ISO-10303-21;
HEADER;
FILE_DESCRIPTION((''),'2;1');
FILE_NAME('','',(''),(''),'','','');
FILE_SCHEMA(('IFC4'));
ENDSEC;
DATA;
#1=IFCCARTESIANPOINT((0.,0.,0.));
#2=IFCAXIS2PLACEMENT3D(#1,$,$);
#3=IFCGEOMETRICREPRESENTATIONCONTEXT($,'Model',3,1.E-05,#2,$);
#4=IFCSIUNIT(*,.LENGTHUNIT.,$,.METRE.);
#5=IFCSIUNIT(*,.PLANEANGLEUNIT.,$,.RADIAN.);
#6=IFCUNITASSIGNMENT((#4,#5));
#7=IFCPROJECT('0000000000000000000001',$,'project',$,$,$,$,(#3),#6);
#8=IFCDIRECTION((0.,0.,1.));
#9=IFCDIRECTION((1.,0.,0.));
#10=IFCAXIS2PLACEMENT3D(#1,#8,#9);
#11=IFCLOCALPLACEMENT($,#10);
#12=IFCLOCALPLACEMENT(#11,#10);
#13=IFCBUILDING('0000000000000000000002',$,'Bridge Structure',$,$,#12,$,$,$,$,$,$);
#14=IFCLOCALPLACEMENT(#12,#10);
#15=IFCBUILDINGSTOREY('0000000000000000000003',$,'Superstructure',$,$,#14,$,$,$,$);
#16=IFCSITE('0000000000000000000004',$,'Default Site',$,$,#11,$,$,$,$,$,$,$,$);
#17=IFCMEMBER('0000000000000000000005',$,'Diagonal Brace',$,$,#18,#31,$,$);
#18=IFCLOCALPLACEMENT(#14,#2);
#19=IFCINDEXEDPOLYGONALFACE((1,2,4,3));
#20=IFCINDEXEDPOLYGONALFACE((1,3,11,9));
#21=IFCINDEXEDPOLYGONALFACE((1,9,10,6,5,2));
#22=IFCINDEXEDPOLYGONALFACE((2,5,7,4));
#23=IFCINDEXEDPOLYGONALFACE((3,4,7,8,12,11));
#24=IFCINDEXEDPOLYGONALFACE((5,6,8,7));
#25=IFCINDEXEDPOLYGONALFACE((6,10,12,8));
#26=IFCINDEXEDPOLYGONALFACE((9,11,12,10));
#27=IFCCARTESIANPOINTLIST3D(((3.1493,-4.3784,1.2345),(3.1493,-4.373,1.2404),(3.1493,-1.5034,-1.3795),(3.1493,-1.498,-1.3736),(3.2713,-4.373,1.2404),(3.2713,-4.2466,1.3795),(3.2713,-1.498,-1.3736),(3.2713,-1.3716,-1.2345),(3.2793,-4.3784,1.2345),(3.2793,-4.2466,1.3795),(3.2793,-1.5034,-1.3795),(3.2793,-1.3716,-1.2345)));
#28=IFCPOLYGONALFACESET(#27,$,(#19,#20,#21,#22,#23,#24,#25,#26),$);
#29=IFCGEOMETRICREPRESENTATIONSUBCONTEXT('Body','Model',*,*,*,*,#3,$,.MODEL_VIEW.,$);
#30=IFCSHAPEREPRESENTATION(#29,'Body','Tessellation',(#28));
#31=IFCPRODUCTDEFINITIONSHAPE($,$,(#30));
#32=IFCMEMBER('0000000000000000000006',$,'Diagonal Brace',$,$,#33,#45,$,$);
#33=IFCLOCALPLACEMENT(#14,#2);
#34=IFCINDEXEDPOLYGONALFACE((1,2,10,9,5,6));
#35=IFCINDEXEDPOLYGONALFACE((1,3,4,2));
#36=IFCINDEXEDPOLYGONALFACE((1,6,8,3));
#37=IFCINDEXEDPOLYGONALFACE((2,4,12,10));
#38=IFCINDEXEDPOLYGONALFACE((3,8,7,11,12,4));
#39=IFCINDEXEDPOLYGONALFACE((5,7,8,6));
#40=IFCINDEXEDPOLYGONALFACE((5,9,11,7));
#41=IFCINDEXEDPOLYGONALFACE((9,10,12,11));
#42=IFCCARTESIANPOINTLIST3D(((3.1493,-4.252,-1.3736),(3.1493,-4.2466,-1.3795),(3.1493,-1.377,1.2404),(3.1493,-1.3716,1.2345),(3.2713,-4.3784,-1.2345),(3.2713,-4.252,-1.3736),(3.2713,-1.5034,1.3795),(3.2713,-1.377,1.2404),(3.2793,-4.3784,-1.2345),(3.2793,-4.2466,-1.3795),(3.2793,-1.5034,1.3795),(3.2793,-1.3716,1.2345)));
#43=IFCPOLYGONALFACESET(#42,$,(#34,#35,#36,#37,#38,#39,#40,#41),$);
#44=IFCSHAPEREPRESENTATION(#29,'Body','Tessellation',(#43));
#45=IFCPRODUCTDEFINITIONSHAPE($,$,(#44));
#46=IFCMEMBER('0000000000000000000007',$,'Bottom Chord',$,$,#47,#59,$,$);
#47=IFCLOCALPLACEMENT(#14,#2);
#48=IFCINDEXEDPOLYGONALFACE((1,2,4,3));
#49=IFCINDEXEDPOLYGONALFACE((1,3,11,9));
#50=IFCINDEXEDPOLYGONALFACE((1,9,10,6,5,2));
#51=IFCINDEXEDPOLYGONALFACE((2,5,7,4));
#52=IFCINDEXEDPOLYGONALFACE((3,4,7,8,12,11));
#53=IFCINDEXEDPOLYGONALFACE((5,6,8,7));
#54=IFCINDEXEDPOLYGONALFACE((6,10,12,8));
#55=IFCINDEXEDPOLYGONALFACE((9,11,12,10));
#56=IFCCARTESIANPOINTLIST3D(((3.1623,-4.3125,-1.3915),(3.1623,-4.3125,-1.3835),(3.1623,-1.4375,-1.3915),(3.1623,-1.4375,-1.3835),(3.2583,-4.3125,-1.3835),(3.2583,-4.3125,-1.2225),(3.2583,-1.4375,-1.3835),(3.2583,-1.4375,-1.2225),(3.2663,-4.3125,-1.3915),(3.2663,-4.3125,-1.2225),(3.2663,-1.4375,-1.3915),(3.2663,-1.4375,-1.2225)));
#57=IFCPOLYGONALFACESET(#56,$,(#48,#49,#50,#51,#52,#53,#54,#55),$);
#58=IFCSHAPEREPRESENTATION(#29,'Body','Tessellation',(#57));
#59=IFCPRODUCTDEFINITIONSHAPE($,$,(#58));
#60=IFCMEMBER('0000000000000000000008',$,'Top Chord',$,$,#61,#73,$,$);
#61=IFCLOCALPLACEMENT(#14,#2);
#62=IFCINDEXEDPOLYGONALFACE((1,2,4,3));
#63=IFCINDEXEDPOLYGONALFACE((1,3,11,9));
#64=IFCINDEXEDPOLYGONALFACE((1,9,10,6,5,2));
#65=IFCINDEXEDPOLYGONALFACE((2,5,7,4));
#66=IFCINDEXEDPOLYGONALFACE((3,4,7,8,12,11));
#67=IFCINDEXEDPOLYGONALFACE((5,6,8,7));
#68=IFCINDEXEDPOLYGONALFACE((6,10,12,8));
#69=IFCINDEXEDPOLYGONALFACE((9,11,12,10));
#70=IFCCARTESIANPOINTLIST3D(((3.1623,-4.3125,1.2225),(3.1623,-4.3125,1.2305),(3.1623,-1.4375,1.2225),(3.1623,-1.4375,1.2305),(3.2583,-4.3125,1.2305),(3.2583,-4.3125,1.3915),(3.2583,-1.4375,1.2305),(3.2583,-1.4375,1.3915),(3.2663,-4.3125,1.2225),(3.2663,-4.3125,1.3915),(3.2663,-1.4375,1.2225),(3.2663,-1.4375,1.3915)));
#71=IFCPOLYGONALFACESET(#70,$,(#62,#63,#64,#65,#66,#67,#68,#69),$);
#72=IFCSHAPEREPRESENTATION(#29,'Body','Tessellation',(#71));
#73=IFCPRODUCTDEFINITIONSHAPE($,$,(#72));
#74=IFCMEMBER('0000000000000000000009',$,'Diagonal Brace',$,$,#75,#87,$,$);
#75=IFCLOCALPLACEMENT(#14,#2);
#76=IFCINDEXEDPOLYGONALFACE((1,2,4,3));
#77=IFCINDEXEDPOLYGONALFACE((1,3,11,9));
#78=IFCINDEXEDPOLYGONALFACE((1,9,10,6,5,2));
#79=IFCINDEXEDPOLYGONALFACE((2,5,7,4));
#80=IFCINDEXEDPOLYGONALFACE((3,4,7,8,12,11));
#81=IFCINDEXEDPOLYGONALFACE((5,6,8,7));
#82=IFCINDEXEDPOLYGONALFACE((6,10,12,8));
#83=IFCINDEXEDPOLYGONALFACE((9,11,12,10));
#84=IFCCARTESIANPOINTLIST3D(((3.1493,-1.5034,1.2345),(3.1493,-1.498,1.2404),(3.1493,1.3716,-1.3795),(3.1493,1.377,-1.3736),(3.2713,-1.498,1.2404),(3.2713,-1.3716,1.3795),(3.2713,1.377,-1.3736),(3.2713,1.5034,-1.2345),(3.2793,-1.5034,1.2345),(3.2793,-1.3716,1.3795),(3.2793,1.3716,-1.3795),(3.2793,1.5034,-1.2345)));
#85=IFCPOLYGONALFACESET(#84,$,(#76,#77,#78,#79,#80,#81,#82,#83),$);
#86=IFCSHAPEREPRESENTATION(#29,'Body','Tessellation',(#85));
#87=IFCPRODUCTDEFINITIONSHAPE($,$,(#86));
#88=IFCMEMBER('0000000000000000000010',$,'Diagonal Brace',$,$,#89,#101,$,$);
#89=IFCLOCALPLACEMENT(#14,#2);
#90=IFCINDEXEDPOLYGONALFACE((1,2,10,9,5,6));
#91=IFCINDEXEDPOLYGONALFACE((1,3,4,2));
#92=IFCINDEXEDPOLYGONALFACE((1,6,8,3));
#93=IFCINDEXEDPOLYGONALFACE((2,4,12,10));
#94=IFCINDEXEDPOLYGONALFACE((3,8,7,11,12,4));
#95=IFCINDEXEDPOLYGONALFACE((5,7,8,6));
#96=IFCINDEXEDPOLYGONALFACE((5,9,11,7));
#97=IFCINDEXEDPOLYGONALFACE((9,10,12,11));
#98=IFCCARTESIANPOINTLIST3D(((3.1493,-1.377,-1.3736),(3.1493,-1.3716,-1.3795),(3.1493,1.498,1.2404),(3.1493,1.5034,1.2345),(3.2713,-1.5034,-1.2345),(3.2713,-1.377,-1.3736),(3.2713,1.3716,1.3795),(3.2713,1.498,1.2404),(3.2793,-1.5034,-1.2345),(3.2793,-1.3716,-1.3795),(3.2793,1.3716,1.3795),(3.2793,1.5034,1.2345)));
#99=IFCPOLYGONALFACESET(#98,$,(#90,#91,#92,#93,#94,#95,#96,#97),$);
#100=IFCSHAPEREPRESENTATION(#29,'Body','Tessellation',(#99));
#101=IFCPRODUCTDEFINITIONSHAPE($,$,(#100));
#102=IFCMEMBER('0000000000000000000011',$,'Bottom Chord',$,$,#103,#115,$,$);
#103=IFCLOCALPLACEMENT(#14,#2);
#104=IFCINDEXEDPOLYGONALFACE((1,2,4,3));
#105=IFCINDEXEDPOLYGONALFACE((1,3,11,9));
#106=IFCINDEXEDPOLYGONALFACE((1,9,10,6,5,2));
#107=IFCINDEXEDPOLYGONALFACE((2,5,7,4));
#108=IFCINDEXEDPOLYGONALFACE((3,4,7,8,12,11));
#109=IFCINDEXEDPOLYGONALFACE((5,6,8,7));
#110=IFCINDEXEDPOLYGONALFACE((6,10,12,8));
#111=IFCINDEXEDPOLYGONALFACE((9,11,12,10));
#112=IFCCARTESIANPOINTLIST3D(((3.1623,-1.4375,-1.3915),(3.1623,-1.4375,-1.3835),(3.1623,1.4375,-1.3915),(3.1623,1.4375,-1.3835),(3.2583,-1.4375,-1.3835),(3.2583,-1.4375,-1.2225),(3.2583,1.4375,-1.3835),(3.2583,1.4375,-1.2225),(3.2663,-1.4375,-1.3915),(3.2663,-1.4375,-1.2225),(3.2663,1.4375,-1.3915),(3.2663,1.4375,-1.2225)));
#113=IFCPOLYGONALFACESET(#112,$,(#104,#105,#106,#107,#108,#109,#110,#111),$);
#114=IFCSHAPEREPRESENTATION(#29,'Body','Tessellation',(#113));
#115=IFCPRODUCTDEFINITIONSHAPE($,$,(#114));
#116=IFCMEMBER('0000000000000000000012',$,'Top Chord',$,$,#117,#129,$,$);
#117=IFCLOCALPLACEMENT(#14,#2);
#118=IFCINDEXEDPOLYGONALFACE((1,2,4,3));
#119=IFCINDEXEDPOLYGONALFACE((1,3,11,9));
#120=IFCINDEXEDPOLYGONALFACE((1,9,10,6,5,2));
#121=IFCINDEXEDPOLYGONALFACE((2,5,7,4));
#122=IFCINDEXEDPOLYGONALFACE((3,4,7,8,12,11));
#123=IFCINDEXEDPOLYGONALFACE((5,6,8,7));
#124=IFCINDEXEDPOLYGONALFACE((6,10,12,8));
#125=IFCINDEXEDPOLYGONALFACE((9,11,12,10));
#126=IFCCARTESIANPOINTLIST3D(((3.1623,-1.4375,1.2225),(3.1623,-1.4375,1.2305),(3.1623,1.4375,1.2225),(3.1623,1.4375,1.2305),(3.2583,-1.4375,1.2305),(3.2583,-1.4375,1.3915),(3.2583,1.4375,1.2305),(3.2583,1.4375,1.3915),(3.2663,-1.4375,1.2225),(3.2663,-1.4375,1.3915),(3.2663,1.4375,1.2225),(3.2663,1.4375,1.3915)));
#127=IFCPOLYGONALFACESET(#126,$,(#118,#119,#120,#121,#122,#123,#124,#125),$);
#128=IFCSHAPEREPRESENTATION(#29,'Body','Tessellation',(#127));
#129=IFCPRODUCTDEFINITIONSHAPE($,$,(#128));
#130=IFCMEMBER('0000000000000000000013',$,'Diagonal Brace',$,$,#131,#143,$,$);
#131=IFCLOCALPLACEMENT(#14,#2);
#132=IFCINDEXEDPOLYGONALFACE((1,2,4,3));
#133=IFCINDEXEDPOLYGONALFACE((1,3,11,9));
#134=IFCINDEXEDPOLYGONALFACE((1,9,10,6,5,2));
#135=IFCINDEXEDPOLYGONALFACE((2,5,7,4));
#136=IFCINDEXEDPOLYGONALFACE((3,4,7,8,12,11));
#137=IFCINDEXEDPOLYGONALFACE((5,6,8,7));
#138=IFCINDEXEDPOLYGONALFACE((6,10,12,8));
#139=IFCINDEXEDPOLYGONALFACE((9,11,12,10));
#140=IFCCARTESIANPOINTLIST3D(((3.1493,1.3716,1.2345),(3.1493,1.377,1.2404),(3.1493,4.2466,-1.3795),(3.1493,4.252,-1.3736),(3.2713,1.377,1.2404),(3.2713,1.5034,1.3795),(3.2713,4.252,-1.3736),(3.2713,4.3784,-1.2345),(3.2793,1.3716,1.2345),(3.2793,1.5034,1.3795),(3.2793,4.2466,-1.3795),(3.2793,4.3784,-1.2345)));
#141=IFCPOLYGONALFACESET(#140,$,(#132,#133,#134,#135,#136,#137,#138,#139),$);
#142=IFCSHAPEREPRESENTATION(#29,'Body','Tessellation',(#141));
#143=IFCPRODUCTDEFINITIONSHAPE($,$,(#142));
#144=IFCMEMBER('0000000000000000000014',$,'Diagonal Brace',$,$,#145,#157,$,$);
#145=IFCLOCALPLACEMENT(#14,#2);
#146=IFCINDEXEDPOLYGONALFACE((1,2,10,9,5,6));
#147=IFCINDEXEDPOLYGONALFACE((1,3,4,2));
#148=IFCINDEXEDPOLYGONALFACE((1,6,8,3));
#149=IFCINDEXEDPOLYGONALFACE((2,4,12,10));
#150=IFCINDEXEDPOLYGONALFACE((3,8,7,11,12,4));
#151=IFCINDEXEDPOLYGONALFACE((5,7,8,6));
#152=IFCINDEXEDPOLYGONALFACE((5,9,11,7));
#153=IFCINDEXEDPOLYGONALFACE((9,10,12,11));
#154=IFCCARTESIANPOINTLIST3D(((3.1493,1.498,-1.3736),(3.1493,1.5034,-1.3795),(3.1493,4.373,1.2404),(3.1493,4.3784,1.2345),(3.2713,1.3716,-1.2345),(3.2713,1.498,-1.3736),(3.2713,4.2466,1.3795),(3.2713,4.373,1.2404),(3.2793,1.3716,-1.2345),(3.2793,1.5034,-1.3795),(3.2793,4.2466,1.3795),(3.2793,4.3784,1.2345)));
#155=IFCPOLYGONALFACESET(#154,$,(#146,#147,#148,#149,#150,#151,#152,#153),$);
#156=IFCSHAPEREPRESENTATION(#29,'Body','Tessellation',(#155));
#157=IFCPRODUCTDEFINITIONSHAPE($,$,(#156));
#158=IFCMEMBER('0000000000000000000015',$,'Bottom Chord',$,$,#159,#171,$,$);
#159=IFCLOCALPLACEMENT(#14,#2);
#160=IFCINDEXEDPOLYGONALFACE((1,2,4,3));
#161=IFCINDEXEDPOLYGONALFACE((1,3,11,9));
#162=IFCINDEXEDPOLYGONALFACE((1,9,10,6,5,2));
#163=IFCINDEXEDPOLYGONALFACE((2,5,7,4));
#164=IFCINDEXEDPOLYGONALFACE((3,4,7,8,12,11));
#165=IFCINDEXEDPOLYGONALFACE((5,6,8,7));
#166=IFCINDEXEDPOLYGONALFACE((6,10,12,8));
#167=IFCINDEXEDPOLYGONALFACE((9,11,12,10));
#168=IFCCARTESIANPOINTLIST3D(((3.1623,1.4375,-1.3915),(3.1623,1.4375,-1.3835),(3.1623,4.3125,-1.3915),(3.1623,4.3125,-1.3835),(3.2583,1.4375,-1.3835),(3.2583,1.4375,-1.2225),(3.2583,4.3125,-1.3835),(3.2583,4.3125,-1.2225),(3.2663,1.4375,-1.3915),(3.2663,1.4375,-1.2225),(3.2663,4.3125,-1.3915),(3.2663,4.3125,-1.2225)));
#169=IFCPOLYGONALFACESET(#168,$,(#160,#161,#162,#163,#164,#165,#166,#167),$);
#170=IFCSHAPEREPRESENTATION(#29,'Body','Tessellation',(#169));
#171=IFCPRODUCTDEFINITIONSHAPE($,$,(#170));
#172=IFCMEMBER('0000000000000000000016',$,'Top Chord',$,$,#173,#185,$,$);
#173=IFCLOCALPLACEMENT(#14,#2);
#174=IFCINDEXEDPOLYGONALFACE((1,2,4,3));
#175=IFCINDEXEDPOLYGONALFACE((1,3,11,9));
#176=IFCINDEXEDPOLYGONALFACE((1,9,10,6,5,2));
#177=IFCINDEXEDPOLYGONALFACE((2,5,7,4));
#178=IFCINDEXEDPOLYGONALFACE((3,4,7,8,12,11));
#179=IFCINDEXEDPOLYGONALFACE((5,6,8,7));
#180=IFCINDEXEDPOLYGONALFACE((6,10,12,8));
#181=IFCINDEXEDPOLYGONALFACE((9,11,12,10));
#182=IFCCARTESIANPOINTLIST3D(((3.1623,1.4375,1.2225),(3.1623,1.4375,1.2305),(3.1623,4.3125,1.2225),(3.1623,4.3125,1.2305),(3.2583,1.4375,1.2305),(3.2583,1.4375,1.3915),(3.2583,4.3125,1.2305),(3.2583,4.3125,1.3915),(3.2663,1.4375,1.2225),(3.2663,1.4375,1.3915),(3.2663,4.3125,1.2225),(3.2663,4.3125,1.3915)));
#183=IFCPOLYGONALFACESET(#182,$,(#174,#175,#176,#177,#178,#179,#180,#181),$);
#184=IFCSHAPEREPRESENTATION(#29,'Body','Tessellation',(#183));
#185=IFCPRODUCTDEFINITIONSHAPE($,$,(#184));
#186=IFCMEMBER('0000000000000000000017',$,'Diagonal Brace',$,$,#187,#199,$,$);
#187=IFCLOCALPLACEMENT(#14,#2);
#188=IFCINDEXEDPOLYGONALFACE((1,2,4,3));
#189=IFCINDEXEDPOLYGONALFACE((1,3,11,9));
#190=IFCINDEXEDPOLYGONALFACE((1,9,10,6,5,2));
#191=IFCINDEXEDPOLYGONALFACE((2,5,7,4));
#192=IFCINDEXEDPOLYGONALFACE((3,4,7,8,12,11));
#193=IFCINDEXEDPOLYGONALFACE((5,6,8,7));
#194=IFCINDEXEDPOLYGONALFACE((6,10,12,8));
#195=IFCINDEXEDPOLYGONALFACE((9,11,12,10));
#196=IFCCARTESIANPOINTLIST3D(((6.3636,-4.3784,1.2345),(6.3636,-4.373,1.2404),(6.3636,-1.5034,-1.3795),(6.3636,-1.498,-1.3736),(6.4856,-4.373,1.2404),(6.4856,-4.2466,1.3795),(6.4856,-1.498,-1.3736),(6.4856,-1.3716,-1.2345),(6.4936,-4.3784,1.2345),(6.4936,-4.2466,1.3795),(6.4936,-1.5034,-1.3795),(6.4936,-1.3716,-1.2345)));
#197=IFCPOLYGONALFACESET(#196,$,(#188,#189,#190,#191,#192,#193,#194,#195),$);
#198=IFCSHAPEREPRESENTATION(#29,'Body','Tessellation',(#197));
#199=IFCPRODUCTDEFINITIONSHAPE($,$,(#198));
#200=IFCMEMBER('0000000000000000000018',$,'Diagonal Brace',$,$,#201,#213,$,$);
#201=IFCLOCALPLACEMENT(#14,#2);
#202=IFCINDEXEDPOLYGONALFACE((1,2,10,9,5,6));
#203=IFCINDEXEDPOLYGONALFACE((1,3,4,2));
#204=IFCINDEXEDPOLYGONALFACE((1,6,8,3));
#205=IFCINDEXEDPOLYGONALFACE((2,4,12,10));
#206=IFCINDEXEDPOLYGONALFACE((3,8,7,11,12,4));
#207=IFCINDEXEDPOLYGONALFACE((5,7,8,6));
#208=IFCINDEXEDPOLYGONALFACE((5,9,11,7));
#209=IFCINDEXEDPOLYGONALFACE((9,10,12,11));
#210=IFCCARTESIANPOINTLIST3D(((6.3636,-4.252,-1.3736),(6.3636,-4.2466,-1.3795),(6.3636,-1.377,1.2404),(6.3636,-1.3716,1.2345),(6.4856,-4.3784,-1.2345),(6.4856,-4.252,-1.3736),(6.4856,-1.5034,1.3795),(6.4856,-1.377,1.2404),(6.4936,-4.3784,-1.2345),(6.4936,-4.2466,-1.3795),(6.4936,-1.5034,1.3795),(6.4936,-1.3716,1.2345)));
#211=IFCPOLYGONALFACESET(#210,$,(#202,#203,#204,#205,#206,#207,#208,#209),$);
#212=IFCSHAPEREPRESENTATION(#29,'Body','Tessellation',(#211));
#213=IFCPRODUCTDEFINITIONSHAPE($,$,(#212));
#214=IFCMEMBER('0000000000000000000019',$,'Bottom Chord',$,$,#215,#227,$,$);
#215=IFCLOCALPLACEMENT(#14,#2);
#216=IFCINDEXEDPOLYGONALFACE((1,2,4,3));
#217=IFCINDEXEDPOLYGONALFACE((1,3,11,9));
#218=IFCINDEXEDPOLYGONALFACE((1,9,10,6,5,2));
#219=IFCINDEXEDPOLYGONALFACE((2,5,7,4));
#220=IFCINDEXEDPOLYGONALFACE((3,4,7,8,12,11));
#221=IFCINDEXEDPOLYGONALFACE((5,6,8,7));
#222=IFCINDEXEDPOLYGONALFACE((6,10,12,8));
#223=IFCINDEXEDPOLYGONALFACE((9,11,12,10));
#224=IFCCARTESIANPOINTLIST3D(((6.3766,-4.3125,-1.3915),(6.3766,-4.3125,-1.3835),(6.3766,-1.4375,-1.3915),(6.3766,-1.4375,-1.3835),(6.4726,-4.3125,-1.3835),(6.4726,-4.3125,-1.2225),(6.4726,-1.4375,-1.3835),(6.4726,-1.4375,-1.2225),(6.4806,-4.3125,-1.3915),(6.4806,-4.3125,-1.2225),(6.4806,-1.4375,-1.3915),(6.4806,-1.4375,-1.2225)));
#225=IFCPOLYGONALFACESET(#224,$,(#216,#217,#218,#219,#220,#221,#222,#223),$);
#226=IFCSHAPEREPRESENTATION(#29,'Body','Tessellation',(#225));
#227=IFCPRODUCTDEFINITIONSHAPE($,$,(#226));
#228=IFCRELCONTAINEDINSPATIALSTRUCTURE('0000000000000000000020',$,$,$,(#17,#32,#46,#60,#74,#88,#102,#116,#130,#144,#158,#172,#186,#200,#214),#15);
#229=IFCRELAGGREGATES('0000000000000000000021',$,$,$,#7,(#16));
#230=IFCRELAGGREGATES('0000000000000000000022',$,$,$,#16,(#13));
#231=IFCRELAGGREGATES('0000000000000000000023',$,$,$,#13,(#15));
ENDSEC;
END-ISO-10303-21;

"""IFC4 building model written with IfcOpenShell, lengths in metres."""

from ifc_helpers import new_model, si_unit, frame, origin, origin_with_axes, origin_2d_with_axis, place, context, subcontext, project, spatial, l_section, extrude, element, save


model = new_model("IFC4")

# Units and contexts
model_context = context("Model", 3, precision=1e-05, world=origin())
body_context = subcontext(model_context, "Body", "Model", "MODEL_VIEW")
ifc_project = project(units=[si_unit("LENGTHUNIT", "METRE"), si_unit("PLANEANGLEUNIT", "RADIAN")], contexts=[model_context])

# Site, building, storey
site_placement = place(None, origin_with_axes())
site = spatial("IfcSite", under=ifc_project, at=site_placement, Name="Default Site")
building_placement = place(site_placement, origin_with_axes())
building = spatial("IfcBuilding", under=site, at=building_placement, Name="Bridge Structure")
storey_placement = place(building_placement, origin_with_axes())
storey = spatial("IfcBuildingStorey", under=building, at=storey_placement, Name="Superstructure")

# Members
for number, where, z_axis, x_axis, name in (
    (1, (3.2143, -4.3125, 1.307), (0.0, 0.739893, -0.672724), (-1.0, 0.0, 0.0), "Diagonal Brace"),
    (2, (3.2143, -4.3125, -1.307), (0.0, 0.739893, 0.672724), (-1.0, 0.0, 0.0), "Diagonal Brace"),
):
    element("IfcMember", number, at=place(storey_placement, frame(where, z_axis=z_axis, x_axis=x_axis)), inside=storey, Name=name, context=body_context, shape_type="SweptSolid", body=[
        extrude(l_section(Depth=0.196, Width=0.13, Thickness=0.008, at=origin_2d_with_axis()), origin_with_axes(), (0.0, 0.0, 1.0), 3.8857),
    ])
for number, where, z_axis, x_axis, name in (
    (3, (3.2143, -4.3125, -1.307), (0.0, 1.0, 0.0), (-1.0, 0.0, 0.0), "Bottom Chord"),
    (4, (3.2143, -4.3125, 1.307), (0.0, 1.0, 0.0), (-1.0, 0.0, 0.0), "Top Chord"),
):
    element("IfcMember", number, at=place(storey_placement, frame(where, z_axis=z_axis, x_axis=x_axis)), inside=storey, Name=name, context=body_context, shape_type="SweptSolid", body=[
        extrude(l_section(Depth=0.169, Width=0.104, Thickness=0.008, at=origin_2d_with_axis()), origin_with_axes(), (0.0, 0.0, 1.0), 2.875),
    ])
for number, where, z_axis, x_axis, name in (
    (5, (3.2143, -1.4375, 1.307), (0.0, 0.739893, -0.672724), (-1.0, 0.0, 0.0), "Diagonal Brace"),
    (6, (3.2143, -1.4375, -1.307), (0.0, 0.739893, 0.672724), (-1.0, 0.0, 0.0), "Diagonal Brace"),
):
    element("IfcMember", number, at=place(storey_placement, frame(where, z_axis=z_axis, x_axis=x_axis)), inside=storey, Name=name, context=body_context, shape_type="SweptSolid", body=[
        extrude(l_section(Depth=0.196, Width=0.13, Thickness=0.008, at=origin_2d_with_axis()), origin_with_axes(), (0.0, 0.0, 1.0), 3.8857),
    ])
for number, where, z_axis, x_axis, name in (
    (7, (3.2143, -1.4375, -1.307), (0.0, 1.0, 0.0), (-1.0, 0.0, 0.0), "Bottom Chord"),
    (8, (3.2143, -1.4375, 1.307), (0.0, 1.0, 0.0), (-1.0, 0.0, 0.0), "Top Chord"),
):
    element("IfcMember", number, at=place(storey_placement, frame(where, z_axis=z_axis, x_axis=x_axis)), inside=storey, Name=name, context=body_context, shape_type="SweptSolid", body=[
        extrude(l_section(Depth=0.169, Width=0.104, Thickness=0.008, at=origin_2d_with_axis()), origin_with_axes(), (0.0, 0.0, 1.0), 2.875),
    ])
for number, where, z_axis, x_axis, name in (
    (9, (3.2143, 1.4375, 1.307), (0.0, 0.739893, -0.672724), (-1.0, 0.0, 0.0), "Diagonal Brace"),
    (10, (3.2143, 1.4375, -1.307), (0.0, 0.739893, 0.672724), (-1.0, 0.0, 0.0), "Diagonal Brace"),
):
    element("IfcMember", number, at=place(storey_placement, frame(where, z_axis=z_axis, x_axis=x_axis)), inside=storey, Name=name, context=body_context, shape_type="SweptSolid", body=[
        extrude(l_section(Depth=0.196, Width=0.13, Thickness=0.008, at=origin_2d_with_axis()), origin_with_axes(), (0.0, 0.0, 1.0), 3.8857),
    ])
for number, where, z_axis, x_axis, name in (
    (11, (3.2143, 1.4375, -1.307), (0.0, 1.0, 0.0), (-1.0, 0.0, 0.0), "Bottom Chord"),
    (12, (3.2143, 1.4375, 1.307), (0.0, 1.0, 0.0), (-1.0, 0.0, 0.0), "Top Chord"),
):
    element("IfcMember", number, at=place(storey_placement, frame(where, z_axis=z_axis, x_axis=x_axis)), inside=storey, Name=name, context=body_context, shape_type="SweptSolid", body=[
        extrude(l_section(Depth=0.169, Width=0.104, Thickness=0.008, at=origin_2d_with_axis()), origin_with_axes(), (0.0, 0.0, 1.0), 2.875),
    ])
for number, where, z_axis, x_axis, name in (
    (13, (6.4286, -4.3125, 1.307), (0.0, 0.739893, -0.672724), (-1.0, 0.0, 0.0), "Diagonal Brace"),
    (14, (6.4286, -4.3125, -1.307), (0.0, 0.739893, 0.672724), (-1.0, 0.0, 0.0), "Diagonal Brace"),
):
    element("IfcMember", number, at=place(storey_placement, frame(where, z_axis=z_axis, x_axis=x_axis)), inside=storey, Name=name, context=body_context, shape_type="SweptSolid", body=[
        extrude(l_section(Depth=0.196, Width=0.13, Thickness=0.008, at=origin_2d_with_axis()), origin_with_axes(), (0.0, 0.0, 1.0), 3.8857),
    ])
for number, where, z_axis, x_axis, name in (
    (15, (6.4286, -4.3125, -1.307), (0.0, 1.0, 0.0), (-1.0, 0.0, 0.0), "Bottom Chord"),
):
    element("IfcMember", number, at=place(storey_placement, frame(where, z_axis=z_axis, x_axis=x_axis)), inside=storey, Name=name, context=body_context, shape_type="SweptSolid", body=[
        extrude(l_section(Depth=0.169, Width=0.104, Thickness=0.008, at=origin_2d_with_axis()), origin_with_axes(), (0.0, 0.0, 1.0), 2.875),
    ])

save(model, "model.ifc")
